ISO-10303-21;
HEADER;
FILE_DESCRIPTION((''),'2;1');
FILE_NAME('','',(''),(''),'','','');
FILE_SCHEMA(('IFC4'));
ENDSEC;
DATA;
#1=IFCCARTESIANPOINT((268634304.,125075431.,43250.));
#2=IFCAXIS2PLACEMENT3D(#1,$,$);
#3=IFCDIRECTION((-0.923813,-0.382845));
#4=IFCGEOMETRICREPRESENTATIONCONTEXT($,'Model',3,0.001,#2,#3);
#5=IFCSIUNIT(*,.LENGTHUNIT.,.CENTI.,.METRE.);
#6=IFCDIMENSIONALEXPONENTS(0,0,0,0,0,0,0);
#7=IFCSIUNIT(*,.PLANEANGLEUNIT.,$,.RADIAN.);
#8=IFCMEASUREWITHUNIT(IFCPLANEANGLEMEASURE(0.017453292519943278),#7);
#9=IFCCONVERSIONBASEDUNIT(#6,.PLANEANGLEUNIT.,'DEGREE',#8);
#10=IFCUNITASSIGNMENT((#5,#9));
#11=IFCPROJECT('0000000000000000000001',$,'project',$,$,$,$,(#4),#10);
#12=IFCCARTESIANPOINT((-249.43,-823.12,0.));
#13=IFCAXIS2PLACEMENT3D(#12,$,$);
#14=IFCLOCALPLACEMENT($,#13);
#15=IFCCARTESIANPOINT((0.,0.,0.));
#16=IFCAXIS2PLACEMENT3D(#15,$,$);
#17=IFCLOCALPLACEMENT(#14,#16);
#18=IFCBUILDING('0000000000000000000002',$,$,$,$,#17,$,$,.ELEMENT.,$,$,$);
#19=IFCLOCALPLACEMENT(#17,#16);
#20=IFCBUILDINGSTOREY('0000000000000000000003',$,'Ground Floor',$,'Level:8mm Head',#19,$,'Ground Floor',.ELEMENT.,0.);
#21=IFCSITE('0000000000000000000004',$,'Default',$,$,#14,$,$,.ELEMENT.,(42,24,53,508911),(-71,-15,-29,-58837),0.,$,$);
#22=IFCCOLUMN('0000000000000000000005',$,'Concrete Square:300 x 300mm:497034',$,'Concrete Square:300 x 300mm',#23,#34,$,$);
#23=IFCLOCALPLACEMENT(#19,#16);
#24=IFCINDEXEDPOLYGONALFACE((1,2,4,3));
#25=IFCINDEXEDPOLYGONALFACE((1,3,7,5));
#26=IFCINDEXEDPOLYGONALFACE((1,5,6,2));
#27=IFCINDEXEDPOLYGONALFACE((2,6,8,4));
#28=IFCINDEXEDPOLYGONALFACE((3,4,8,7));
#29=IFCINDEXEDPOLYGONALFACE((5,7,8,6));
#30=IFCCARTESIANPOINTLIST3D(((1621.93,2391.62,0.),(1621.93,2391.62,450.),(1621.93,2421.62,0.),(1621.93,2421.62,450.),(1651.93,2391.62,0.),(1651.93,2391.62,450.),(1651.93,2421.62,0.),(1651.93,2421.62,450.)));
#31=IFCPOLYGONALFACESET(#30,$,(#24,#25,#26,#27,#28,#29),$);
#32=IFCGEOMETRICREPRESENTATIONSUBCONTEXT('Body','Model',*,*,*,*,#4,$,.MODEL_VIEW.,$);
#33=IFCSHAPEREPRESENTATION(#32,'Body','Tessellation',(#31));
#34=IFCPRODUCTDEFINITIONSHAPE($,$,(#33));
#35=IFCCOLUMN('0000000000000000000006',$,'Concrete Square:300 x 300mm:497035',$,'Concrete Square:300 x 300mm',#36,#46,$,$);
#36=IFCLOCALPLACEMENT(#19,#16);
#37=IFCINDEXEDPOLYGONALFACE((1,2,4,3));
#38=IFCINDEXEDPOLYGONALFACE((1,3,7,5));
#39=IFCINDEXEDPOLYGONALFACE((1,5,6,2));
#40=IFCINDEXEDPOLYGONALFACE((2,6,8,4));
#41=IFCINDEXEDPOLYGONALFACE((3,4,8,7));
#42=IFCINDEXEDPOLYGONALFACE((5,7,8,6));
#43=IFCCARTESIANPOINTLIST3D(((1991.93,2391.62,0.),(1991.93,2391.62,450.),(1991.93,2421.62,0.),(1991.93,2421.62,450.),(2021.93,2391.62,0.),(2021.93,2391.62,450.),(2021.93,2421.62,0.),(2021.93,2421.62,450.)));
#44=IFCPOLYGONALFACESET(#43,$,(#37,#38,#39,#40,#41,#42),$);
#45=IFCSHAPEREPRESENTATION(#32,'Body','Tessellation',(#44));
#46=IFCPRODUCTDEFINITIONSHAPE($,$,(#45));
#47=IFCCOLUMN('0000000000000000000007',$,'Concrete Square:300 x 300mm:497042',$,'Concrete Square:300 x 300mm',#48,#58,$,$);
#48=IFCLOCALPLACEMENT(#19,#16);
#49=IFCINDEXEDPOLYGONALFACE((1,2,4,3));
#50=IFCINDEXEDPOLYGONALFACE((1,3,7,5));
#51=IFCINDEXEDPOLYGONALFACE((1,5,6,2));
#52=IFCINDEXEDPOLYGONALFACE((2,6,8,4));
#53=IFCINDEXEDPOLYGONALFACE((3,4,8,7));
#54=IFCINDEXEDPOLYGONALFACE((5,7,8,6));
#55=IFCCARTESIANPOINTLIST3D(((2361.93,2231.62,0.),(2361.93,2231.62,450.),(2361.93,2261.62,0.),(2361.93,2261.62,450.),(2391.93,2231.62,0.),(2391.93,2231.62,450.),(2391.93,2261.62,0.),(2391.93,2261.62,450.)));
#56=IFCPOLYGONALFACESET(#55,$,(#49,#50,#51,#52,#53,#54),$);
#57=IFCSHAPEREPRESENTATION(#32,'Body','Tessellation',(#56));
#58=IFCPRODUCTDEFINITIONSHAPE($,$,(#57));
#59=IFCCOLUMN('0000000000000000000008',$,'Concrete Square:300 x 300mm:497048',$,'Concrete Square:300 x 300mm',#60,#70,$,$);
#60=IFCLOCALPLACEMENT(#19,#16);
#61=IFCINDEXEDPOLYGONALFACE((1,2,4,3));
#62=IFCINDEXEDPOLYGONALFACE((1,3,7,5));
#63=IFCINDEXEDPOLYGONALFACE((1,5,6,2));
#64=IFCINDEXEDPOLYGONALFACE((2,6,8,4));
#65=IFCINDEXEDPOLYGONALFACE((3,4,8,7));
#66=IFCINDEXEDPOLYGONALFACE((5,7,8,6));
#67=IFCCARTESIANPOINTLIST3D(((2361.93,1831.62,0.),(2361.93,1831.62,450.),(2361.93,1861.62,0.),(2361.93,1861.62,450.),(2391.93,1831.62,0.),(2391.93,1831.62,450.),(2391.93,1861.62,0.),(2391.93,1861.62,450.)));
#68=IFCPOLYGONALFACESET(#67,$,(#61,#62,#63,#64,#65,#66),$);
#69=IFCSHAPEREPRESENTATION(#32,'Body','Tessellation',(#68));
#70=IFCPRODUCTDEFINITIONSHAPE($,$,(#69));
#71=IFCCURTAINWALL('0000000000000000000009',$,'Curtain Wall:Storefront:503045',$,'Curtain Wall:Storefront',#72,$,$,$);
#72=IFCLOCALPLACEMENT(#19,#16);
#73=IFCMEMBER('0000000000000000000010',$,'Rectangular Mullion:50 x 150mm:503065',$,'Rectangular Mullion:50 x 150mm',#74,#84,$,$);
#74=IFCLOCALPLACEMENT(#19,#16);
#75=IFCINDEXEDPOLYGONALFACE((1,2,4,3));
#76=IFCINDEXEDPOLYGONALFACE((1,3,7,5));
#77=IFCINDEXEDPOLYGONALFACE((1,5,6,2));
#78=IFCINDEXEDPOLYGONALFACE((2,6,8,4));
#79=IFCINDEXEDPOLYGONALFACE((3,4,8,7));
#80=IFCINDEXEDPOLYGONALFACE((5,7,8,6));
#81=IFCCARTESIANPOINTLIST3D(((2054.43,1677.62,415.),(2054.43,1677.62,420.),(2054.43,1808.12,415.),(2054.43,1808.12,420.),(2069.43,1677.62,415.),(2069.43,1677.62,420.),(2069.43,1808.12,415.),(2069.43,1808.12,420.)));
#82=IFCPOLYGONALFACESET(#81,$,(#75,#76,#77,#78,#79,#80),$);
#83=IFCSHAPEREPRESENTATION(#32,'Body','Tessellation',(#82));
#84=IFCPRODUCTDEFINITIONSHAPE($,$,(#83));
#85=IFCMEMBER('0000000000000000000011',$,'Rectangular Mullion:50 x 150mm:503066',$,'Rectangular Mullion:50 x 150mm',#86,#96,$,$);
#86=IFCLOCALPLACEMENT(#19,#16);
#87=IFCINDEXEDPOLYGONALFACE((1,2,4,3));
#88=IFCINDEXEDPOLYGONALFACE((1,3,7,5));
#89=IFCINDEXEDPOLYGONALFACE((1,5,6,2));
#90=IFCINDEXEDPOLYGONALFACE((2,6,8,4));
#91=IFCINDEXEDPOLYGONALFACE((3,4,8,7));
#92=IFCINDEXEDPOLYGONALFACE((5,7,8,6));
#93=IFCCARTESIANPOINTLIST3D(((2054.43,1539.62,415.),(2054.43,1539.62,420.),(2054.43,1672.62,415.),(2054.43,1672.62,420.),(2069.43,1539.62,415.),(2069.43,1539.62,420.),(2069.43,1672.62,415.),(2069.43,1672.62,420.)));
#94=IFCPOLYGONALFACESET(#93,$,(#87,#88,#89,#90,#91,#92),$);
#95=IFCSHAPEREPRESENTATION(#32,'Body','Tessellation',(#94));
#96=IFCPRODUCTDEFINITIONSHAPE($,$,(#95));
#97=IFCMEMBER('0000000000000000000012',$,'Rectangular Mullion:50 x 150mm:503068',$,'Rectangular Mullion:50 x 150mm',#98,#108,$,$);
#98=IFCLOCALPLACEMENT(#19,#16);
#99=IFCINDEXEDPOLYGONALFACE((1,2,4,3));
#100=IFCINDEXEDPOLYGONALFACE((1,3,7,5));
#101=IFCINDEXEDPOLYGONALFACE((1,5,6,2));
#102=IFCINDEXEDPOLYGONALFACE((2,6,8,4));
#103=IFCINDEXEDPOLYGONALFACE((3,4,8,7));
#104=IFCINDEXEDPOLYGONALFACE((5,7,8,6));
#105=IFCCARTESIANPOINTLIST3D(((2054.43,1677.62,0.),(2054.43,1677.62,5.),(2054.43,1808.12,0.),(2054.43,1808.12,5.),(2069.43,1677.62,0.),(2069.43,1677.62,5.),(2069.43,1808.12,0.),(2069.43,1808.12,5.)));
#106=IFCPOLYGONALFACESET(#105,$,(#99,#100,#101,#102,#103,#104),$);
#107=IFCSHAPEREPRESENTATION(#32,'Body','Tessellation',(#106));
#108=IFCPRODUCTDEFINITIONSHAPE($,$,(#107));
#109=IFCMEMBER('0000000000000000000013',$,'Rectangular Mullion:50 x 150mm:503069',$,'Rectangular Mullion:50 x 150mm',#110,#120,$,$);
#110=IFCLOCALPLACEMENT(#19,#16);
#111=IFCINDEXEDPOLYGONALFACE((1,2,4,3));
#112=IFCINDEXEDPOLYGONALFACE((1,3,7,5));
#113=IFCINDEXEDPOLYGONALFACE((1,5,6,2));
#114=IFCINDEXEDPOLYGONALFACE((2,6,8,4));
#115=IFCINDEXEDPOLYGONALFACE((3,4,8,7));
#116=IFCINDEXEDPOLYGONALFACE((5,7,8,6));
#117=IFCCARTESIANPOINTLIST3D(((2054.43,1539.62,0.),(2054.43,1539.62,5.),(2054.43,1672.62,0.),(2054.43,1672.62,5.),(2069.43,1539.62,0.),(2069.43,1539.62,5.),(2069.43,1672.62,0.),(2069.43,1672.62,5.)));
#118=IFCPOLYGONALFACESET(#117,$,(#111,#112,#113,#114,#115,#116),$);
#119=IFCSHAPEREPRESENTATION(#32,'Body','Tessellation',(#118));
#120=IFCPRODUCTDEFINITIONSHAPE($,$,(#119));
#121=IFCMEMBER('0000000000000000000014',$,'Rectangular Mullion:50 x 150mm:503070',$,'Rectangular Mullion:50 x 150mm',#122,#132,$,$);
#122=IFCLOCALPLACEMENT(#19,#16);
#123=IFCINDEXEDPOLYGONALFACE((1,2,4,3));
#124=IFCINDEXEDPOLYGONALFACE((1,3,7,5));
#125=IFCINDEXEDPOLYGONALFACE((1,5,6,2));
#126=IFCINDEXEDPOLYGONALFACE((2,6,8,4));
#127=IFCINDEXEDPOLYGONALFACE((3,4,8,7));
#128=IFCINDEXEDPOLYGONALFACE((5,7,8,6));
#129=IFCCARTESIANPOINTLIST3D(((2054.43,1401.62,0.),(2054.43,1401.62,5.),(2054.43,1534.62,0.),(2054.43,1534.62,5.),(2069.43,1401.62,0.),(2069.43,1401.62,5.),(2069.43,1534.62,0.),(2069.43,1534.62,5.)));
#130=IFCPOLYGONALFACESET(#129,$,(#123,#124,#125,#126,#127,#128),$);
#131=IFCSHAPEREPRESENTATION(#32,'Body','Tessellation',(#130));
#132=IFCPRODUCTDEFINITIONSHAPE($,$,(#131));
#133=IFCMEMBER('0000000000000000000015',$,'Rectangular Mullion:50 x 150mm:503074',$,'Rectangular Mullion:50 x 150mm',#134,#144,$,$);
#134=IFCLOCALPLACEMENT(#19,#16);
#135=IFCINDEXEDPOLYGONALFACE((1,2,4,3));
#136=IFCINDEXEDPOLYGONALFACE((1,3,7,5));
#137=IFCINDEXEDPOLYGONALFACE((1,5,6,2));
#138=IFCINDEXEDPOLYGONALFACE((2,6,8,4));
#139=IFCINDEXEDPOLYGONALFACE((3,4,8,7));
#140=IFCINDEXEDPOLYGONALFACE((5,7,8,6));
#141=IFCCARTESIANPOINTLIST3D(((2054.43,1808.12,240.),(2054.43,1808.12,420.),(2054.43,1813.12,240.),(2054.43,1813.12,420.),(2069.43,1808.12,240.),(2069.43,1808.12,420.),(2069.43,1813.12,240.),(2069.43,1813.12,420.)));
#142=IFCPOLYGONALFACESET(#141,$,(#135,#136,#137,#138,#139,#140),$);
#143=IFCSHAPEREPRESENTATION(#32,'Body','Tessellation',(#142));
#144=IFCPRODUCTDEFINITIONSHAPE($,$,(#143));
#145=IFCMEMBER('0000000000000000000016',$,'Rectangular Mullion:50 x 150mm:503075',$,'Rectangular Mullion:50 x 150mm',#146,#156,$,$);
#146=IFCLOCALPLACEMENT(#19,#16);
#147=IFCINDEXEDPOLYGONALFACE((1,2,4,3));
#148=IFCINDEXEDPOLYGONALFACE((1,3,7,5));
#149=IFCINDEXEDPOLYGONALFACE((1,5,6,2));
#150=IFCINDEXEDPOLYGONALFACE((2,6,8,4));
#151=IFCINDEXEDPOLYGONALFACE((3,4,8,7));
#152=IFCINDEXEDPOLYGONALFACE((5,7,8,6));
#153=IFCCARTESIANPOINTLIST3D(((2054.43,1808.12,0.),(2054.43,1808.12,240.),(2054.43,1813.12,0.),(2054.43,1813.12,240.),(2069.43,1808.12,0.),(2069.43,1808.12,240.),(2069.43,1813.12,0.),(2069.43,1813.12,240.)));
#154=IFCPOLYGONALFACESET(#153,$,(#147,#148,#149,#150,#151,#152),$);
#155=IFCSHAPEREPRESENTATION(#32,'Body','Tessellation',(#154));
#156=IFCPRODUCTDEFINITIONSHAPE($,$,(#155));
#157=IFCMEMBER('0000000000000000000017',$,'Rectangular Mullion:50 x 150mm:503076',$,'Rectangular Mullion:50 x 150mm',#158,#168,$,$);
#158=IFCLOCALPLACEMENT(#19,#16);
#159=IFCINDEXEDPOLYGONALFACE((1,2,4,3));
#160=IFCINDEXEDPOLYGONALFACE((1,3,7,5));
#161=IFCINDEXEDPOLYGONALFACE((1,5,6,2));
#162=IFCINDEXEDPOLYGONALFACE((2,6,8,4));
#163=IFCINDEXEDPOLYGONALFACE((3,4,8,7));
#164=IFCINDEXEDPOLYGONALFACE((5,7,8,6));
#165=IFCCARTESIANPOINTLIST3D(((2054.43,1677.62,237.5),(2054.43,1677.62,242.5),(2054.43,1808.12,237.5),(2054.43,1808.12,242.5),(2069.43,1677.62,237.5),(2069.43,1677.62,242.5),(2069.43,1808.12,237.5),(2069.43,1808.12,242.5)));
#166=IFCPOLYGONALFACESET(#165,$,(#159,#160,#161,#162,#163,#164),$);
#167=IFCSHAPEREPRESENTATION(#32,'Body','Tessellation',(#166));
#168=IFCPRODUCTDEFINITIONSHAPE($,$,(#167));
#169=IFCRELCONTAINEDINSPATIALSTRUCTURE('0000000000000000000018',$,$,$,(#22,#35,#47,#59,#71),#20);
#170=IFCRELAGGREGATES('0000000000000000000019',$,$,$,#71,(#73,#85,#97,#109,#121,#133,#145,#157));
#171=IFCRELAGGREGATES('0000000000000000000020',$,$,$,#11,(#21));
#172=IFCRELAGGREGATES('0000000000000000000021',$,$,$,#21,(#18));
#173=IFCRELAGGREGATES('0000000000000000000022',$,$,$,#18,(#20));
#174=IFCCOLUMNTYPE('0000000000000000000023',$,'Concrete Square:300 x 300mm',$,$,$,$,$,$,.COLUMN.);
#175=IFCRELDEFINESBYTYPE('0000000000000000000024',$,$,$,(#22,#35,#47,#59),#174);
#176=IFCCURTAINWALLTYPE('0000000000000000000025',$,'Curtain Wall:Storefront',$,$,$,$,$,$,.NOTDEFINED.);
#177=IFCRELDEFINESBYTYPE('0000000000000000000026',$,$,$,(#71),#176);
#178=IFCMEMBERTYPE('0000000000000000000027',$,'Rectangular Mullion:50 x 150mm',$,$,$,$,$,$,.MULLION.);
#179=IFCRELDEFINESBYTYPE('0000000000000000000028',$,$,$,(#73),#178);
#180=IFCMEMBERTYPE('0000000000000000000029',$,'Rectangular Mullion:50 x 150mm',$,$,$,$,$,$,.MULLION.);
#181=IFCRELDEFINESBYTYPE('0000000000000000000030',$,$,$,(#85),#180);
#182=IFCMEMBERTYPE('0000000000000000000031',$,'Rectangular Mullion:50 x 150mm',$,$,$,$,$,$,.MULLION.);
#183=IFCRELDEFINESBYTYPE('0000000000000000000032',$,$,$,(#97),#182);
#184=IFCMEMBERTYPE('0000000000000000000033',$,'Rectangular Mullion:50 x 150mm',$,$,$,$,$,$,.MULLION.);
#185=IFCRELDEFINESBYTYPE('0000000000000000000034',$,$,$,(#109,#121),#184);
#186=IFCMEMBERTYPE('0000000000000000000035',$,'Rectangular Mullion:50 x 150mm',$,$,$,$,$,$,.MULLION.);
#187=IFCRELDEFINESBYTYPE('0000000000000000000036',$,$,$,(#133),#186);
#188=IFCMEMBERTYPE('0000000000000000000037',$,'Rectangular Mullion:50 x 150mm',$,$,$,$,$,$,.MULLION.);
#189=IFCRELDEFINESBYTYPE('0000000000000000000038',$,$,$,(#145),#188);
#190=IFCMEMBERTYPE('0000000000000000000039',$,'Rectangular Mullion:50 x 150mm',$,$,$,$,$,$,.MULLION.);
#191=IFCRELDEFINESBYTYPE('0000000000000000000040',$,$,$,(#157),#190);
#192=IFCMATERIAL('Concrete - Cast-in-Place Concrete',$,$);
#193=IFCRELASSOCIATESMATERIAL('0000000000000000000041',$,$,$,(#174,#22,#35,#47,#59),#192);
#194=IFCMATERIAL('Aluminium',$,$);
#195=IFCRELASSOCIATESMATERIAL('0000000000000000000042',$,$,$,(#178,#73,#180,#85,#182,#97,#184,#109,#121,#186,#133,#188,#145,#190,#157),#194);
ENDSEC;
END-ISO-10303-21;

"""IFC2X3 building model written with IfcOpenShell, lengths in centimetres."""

from ifc_helpers import new_model, entity, si_unit, converted_unit, direction, frame, origin, origin_2d_with_axis, place, context, subcontext, project, spatial, rectangle, extrude, source, transform, mapped, material, type_object, type_shapes, element, aggregate, save


model = new_model("IFC2X3")

# Units and contexts
model_context = context("Model", 3, precision=0.001, world=frame((268634304.0, 125075431.0, 43250.0)), true_north=direction((-0.923813, -0.382845)))
body_context = subcontext(model_context, "Body", "Model", "MODEL_VIEW")
ifc_project = project(units=[si_unit("LENGTHUNIT", "METRE", prefix="CENTI"), converted_unit("PLANEANGLEUNIT", "DEGREE", entity("IfcPlaneAngleMeasure", 0.017453292519943278), si_unit("PLANEANGLEUNIT", "RADIAN"), dimensions=[0, 0, 0, 0, 0, 0, 0])], contexts=[model_context])

# Site, building, storey
site_placement = place(None, frame((-249.43, -823.12, 0.0)))
site = spatial("IfcSite", under=ifc_project, at=site_placement, Name="Default", CompositionType="ELEMENT", RefLatitude=(42, 24, 53, 508911), RefLongitude=(-71, -15, -29, -58837), RefElevation=0.0)
building_placement = place(site_placement, origin())
building = spatial("IfcBuilding", under=site, at=building_placement, CompositionType="ELEMENT")
storey_placement = place(building_placement, origin())
storey = spatial("IfcBuildingStorey", under=building, at=storey_placement, Name="Ground Floor", ObjectType="Level:8mm Head", LongName="Ground Floor", CompositionType="ELEMENT", Elevation=0.0)

# Columns
ifc_material_1 = material(Name="Concrete - Cast-in-Place Concrete")
column_type = type_object("IfcColumnType", Name="Concrete Square:300 x 300mm", PredefinedType="COLUMN", material=ifc_material_1)
shared_shape_1 = source(origin(), body_context, "Body", "SweptSolid", [
    extrude(rectangle(XDim=30.0, YDim=30.0, at=origin_2d_with_axis()), frame((0.0, 0.0, 0.0), z_axis=(0.0, 0.0, 1.0), x_axis=(-1.0, 0.0, 0.0)), (0.0, 0.0, 1.0), 450.0),
])
type_shapes(column_type, [shared_shape_1])
for number, where, name in (
    (1, (1636.93, 2406.62, 0.0), "Concrete Square:300 x 300mm:497034"),
    (2, (2006.93, 2406.62, 0.0), "Concrete Square:300 x 300mm:497035"),
    (3, (2376.93, 2246.62, 0.0), "Concrete Square:300 x 300mm:497042"),
    (4, (2376.93, 1846.62, 0.0), "Concrete Square:300 x 300mm:497048"),
):
    element("IfcColumn", number, at=place(storey_placement, frame(where)), inside=storey, type_object=column_type, material=ifc_material_1, Name=name, ObjectType="Concrete Square:300 x 300mm", context=body_context, shape_type="MappedRepresentation", body=[
        mapped(shared_shape_1, transform((0.0, 0.0, 0.0), scale=1.0)),
    ])

# Curtain wall, members
curtain_wall_type = type_object("IfcCurtainWallType", Name="Curtain Wall:Storefront", PredefinedType="NOTDEFINED")
curtain_wall_placement = place(storey_placement, origin())
curtain_wall = element("IfcCurtainWall", 5, at=curtain_wall_placement, inside=storey, type_object=curtain_wall_type, Name="Curtain Wall:Storefront:503045", ObjectType="Curtain Wall:Storefront")
ifc_material_2 = material(Name="Aluminium")
member_type_1 = type_object("IfcMemberType", Name="Rectangular Mullion:50 x 150mm", PredefinedType="MULLION", material=ifc_material_2)
shared_shape_2 = source(origin(), body_context, "Body", "SweptSolid", [
    extrude(rectangle(XDim=5.0, YDim=15.0, at=origin_2d_with_axis()), frame((-2.5, 0.0, -130.5), z_axis=(0.0, 0.0, 1.0), x_axis=(-1.0, 0.0, 0.0)), (0.0, 0.0, 1.0), 130.5),
])
type_shapes(member_type_1, [shared_shape_2])
member_1_placement = place(curtain_wall_placement, frame((2061.93, 1677.62, 420.0), z_axis=(0.0, -1.0, 0.0), x_axis=(0.0, 0.0, 1.0)))
member_1 = element("IfcMember", 6, at=member_1_placement, type_object=member_type_1, material=ifc_material_2, Name="Rectangular Mullion:50 x 150mm:503065", ObjectType="Rectangular Mullion:50 x 150mm", context=body_context, shape_type="MappedRepresentation", body=[
    mapped(shared_shape_2, transform((0.0, 0.0, 0.0), scale=1.0)),
])
member_type_2 = type_object("IfcMemberType", Name="Rectangular Mullion:50 x 150mm", PredefinedType="MULLION", material=ifc_material_2)
shared_shape_3 = source(origin(), body_context, "Body", "SweptSolid", [
    extrude(rectangle(XDim=5.0, YDim=15.0, at=origin_2d_with_axis()), frame((-2.5, 0.0, -133.0), z_axis=(0.0, 0.0, 1.0), x_axis=(-1.0, 0.0, 0.0)), (0.0, 0.0, 1.0), 133.0),
])
type_shapes(member_type_2, [shared_shape_3])
member_2_placement = place(curtain_wall_placement, frame((2061.93, 1539.62, 420.0), z_axis=(0.0, -1.0, 0.0), x_axis=(0.0, 0.0, 1.0)))
member_2 = element("IfcMember", 7, at=member_2_placement, type_object=member_type_2, material=ifc_material_2, Name="Rectangular Mullion:50 x 150mm:503066", ObjectType="Rectangular Mullion:50 x 150mm", context=body_context, shape_type="MappedRepresentation", body=[
    mapped(shared_shape_3, transform((0.0, 0.0, 0.0), scale=1.0)),
])
member_type_3 = type_object("IfcMemberType", Name="Rectangular Mullion:50 x 150mm", PredefinedType="MULLION", material=ifc_material_2)
shared_shape_4 = source(origin(), body_context, "Body", "SweptSolid", [
    extrude(rectangle(XDim=5.0, YDim=15.0, at=origin_2d_with_axis()), frame((-2.5, 0.0, -130.5), z_axis=(0.0, 0.0, 1.0), x_axis=(-1.0, 0.0, 0.0)), (0.0, 0.0, 1.0), 130.5),
])
type_shapes(member_type_3, [shared_shape_4])
member_3_placement = place(curtain_wall_placement, frame((2061.93, 1808.12, 0.0), z_axis=(0.0, 1.0, 0.0), x_axis=(0.0, 0.0, -1.0)))
member_3 = element("IfcMember", 8, at=member_3_placement, type_object=member_type_3, material=ifc_material_2, Name="Rectangular Mullion:50 x 150mm:503068", ObjectType="Rectangular Mullion:50 x 150mm", context=body_context, shape_type="MappedRepresentation", body=[
    mapped(shared_shape_4, transform((0.0, 0.0, 0.0), scale=1.0)),
])
member_type_4 = type_object("IfcMemberType", Name="Rectangular Mullion:50 x 150mm", PredefinedType="MULLION", material=ifc_material_2)
shared_shape_5 = source(origin(), body_context, "Body", "SweptSolid", [
    extrude(rectangle(XDim=5.0, YDim=15.0, at=origin_2d_with_axis()), frame((-2.5, 0.0, -133.0), z_axis=(0.0, 0.0, 1.0), x_axis=(-1.0, 0.0, 0.0)), (0.0, 0.0, 1.0), 133.0),
])
type_shapes(member_type_4, [shared_shape_5])
member_4_placement = place(curtain_wall_placement, frame((2061.93, 1672.62, 0.0), z_axis=(0.0, 1.0, 0.0), x_axis=(0.0, 0.0, -1.0)))
member_4 = element("IfcMember", 9, at=member_4_placement, type_object=member_type_4, material=ifc_material_2, Name="Rectangular Mullion:50 x 150mm:503069", ObjectType="Rectangular Mullion:50 x 150mm", context=body_context, shape_type="MappedRepresentation", body=[
    mapped(shared_shape_5, transform((0.0, 0.0, 0.0), scale=1.0)),
])
member_5_placement = place(curtain_wall_placement, frame((2061.93, 1534.62, 0.0), z_axis=(0.0, 1.0, 0.0), x_axis=(0.0, 0.0, -1.0)))
member_5 = element("IfcMember", 10, at=member_5_placement, type_object=member_type_4, material=ifc_material_2, Name="Rectangular Mullion:50 x 150mm:503070", ObjectType="Rectangular Mullion:50 x 150mm", context=body_context, shape_type="MappedRepresentation", body=[
    mapped(shared_shape_5, transform((0.0, 0.0, 0.0), scale=1.0)),
])
member_type_5 = type_object("IfcMemberType", Name="Rectangular Mullion:50 x 150mm", PredefinedType="MULLION", material=ifc_material_2)
shared_shape_6 = source(origin(), body_context, "Body", "SweptSolid", [
    extrude(rectangle(XDim=5.0, YDim=15.0, at=origin_2d_with_axis()), frame((-2.5, 0.0, -180.0), z_axis=(0.0, 0.0, 1.0), x_axis=(-1.0, 0.0, 0.0)), (0.0, 0.0, 1.0), 180.0),
])
type_shapes(member_type_5, [shared_shape_6])
member_6_placement = place(curtain_wall_placement, frame((2061.93, 1813.12, 420.0), z_axis=(0.0, 0.0, 1.0), x_axis=(0.0, 1.0, 0.0)))
member_6 = element("IfcMember", 11, at=member_6_placement, type_object=member_type_5, material=ifc_material_2, Name="Rectangular Mullion:50 x 150mm:503074", ObjectType="Rectangular Mullion:50 x 150mm", context=body_context, shape_type="MappedRepresentation", body=[
    mapped(shared_shape_6, transform((0.0, 0.0, 0.0), scale=1.0)),
])
member_type_6 = type_object("IfcMemberType", Name="Rectangular Mullion:50 x 150mm", PredefinedType="MULLION", material=ifc_material_2)
shared_shape_7 = source(origin(), body_context, "Body", "SweptSolid", [
    extrude(rectangle(XDim=5.0, YDim=15.0, at=origin_2d_with_axis()), frame((-2.5, 0.0, -240.0), z_axis=(0.0, 0.0, 1.0), x_axis=(-1.0, 0.0, 0.0)), (0.0, 0.0, 1.0), 240.0),
])
type_shapes(member_type_6, [shared_shape_7])
member_7_placement = place(curtain_wall_placement, frame((2061.93, 1813.12, 240.0), z_axis=(0.0, 0.0, 1.0), x_axis=(0.0, 1.0, 0.0)))
member_7 = element("IfcMember", 12, at=member_7_placement, type_object=member_type_6, material=ifc_material_2, Name="Rectangular Mullion:50 x 150mm:503075", ObjectType="Rectangular Mullion:50 x 150mm", context=body_context, shape_type="MappedRepresentation", body=[
    mapped(shared_shape_7, transform((0.0, 0.0, 0.0), scale=1.0)),
])
member_type_7 = type_object("IfcMemberType", Name="Rectangular Mullion:50 x 150mm", PredefinedType="MULLION", material=ifc_material_2)
shared_shape_8 = source(origin(), body_context, "Body", "SweptSolid", [
    extrude(rectangle(XDim=5.0, YDim=15.0, at=origin_2d_with_axis()), frame((0.0, 0.0, -130.5), z_axis=(0.0, 0.0, 1.0), x_axis=(-1.0, 0.0, 0.0)), (0.0, 0.0, 1.0), 130.5),
])
type_shapes(member_type_7, [shared_shape_8])
member_8_placement = place(curtain_wall_placement, frame((2061.93, 1677.62, 240.0), z_axis=(0.0, -1.0, 0.0), x_axis=(0.0, 0.0, 1.0)))
member_8 = element("IfcMember", 13, at=member_8_placement, type_object=member_type_7, material=ifc_material_2, Name="Rectangular Mullion:50 x 150mm:503076", ObjectType="Rectangular Mullion:50 x 150mm", context=body_context, shape_type="MappedRepresentation", body=[
    mapped(shared_shape_8, transform((0.0, 0.0, 0.0), scale=1.0)),
])
aggregate(curtain_wall, [member_1, member_2, member_3, member_4, member_5, member_6, member_7, member_8])

save(model, "model.ifc")
